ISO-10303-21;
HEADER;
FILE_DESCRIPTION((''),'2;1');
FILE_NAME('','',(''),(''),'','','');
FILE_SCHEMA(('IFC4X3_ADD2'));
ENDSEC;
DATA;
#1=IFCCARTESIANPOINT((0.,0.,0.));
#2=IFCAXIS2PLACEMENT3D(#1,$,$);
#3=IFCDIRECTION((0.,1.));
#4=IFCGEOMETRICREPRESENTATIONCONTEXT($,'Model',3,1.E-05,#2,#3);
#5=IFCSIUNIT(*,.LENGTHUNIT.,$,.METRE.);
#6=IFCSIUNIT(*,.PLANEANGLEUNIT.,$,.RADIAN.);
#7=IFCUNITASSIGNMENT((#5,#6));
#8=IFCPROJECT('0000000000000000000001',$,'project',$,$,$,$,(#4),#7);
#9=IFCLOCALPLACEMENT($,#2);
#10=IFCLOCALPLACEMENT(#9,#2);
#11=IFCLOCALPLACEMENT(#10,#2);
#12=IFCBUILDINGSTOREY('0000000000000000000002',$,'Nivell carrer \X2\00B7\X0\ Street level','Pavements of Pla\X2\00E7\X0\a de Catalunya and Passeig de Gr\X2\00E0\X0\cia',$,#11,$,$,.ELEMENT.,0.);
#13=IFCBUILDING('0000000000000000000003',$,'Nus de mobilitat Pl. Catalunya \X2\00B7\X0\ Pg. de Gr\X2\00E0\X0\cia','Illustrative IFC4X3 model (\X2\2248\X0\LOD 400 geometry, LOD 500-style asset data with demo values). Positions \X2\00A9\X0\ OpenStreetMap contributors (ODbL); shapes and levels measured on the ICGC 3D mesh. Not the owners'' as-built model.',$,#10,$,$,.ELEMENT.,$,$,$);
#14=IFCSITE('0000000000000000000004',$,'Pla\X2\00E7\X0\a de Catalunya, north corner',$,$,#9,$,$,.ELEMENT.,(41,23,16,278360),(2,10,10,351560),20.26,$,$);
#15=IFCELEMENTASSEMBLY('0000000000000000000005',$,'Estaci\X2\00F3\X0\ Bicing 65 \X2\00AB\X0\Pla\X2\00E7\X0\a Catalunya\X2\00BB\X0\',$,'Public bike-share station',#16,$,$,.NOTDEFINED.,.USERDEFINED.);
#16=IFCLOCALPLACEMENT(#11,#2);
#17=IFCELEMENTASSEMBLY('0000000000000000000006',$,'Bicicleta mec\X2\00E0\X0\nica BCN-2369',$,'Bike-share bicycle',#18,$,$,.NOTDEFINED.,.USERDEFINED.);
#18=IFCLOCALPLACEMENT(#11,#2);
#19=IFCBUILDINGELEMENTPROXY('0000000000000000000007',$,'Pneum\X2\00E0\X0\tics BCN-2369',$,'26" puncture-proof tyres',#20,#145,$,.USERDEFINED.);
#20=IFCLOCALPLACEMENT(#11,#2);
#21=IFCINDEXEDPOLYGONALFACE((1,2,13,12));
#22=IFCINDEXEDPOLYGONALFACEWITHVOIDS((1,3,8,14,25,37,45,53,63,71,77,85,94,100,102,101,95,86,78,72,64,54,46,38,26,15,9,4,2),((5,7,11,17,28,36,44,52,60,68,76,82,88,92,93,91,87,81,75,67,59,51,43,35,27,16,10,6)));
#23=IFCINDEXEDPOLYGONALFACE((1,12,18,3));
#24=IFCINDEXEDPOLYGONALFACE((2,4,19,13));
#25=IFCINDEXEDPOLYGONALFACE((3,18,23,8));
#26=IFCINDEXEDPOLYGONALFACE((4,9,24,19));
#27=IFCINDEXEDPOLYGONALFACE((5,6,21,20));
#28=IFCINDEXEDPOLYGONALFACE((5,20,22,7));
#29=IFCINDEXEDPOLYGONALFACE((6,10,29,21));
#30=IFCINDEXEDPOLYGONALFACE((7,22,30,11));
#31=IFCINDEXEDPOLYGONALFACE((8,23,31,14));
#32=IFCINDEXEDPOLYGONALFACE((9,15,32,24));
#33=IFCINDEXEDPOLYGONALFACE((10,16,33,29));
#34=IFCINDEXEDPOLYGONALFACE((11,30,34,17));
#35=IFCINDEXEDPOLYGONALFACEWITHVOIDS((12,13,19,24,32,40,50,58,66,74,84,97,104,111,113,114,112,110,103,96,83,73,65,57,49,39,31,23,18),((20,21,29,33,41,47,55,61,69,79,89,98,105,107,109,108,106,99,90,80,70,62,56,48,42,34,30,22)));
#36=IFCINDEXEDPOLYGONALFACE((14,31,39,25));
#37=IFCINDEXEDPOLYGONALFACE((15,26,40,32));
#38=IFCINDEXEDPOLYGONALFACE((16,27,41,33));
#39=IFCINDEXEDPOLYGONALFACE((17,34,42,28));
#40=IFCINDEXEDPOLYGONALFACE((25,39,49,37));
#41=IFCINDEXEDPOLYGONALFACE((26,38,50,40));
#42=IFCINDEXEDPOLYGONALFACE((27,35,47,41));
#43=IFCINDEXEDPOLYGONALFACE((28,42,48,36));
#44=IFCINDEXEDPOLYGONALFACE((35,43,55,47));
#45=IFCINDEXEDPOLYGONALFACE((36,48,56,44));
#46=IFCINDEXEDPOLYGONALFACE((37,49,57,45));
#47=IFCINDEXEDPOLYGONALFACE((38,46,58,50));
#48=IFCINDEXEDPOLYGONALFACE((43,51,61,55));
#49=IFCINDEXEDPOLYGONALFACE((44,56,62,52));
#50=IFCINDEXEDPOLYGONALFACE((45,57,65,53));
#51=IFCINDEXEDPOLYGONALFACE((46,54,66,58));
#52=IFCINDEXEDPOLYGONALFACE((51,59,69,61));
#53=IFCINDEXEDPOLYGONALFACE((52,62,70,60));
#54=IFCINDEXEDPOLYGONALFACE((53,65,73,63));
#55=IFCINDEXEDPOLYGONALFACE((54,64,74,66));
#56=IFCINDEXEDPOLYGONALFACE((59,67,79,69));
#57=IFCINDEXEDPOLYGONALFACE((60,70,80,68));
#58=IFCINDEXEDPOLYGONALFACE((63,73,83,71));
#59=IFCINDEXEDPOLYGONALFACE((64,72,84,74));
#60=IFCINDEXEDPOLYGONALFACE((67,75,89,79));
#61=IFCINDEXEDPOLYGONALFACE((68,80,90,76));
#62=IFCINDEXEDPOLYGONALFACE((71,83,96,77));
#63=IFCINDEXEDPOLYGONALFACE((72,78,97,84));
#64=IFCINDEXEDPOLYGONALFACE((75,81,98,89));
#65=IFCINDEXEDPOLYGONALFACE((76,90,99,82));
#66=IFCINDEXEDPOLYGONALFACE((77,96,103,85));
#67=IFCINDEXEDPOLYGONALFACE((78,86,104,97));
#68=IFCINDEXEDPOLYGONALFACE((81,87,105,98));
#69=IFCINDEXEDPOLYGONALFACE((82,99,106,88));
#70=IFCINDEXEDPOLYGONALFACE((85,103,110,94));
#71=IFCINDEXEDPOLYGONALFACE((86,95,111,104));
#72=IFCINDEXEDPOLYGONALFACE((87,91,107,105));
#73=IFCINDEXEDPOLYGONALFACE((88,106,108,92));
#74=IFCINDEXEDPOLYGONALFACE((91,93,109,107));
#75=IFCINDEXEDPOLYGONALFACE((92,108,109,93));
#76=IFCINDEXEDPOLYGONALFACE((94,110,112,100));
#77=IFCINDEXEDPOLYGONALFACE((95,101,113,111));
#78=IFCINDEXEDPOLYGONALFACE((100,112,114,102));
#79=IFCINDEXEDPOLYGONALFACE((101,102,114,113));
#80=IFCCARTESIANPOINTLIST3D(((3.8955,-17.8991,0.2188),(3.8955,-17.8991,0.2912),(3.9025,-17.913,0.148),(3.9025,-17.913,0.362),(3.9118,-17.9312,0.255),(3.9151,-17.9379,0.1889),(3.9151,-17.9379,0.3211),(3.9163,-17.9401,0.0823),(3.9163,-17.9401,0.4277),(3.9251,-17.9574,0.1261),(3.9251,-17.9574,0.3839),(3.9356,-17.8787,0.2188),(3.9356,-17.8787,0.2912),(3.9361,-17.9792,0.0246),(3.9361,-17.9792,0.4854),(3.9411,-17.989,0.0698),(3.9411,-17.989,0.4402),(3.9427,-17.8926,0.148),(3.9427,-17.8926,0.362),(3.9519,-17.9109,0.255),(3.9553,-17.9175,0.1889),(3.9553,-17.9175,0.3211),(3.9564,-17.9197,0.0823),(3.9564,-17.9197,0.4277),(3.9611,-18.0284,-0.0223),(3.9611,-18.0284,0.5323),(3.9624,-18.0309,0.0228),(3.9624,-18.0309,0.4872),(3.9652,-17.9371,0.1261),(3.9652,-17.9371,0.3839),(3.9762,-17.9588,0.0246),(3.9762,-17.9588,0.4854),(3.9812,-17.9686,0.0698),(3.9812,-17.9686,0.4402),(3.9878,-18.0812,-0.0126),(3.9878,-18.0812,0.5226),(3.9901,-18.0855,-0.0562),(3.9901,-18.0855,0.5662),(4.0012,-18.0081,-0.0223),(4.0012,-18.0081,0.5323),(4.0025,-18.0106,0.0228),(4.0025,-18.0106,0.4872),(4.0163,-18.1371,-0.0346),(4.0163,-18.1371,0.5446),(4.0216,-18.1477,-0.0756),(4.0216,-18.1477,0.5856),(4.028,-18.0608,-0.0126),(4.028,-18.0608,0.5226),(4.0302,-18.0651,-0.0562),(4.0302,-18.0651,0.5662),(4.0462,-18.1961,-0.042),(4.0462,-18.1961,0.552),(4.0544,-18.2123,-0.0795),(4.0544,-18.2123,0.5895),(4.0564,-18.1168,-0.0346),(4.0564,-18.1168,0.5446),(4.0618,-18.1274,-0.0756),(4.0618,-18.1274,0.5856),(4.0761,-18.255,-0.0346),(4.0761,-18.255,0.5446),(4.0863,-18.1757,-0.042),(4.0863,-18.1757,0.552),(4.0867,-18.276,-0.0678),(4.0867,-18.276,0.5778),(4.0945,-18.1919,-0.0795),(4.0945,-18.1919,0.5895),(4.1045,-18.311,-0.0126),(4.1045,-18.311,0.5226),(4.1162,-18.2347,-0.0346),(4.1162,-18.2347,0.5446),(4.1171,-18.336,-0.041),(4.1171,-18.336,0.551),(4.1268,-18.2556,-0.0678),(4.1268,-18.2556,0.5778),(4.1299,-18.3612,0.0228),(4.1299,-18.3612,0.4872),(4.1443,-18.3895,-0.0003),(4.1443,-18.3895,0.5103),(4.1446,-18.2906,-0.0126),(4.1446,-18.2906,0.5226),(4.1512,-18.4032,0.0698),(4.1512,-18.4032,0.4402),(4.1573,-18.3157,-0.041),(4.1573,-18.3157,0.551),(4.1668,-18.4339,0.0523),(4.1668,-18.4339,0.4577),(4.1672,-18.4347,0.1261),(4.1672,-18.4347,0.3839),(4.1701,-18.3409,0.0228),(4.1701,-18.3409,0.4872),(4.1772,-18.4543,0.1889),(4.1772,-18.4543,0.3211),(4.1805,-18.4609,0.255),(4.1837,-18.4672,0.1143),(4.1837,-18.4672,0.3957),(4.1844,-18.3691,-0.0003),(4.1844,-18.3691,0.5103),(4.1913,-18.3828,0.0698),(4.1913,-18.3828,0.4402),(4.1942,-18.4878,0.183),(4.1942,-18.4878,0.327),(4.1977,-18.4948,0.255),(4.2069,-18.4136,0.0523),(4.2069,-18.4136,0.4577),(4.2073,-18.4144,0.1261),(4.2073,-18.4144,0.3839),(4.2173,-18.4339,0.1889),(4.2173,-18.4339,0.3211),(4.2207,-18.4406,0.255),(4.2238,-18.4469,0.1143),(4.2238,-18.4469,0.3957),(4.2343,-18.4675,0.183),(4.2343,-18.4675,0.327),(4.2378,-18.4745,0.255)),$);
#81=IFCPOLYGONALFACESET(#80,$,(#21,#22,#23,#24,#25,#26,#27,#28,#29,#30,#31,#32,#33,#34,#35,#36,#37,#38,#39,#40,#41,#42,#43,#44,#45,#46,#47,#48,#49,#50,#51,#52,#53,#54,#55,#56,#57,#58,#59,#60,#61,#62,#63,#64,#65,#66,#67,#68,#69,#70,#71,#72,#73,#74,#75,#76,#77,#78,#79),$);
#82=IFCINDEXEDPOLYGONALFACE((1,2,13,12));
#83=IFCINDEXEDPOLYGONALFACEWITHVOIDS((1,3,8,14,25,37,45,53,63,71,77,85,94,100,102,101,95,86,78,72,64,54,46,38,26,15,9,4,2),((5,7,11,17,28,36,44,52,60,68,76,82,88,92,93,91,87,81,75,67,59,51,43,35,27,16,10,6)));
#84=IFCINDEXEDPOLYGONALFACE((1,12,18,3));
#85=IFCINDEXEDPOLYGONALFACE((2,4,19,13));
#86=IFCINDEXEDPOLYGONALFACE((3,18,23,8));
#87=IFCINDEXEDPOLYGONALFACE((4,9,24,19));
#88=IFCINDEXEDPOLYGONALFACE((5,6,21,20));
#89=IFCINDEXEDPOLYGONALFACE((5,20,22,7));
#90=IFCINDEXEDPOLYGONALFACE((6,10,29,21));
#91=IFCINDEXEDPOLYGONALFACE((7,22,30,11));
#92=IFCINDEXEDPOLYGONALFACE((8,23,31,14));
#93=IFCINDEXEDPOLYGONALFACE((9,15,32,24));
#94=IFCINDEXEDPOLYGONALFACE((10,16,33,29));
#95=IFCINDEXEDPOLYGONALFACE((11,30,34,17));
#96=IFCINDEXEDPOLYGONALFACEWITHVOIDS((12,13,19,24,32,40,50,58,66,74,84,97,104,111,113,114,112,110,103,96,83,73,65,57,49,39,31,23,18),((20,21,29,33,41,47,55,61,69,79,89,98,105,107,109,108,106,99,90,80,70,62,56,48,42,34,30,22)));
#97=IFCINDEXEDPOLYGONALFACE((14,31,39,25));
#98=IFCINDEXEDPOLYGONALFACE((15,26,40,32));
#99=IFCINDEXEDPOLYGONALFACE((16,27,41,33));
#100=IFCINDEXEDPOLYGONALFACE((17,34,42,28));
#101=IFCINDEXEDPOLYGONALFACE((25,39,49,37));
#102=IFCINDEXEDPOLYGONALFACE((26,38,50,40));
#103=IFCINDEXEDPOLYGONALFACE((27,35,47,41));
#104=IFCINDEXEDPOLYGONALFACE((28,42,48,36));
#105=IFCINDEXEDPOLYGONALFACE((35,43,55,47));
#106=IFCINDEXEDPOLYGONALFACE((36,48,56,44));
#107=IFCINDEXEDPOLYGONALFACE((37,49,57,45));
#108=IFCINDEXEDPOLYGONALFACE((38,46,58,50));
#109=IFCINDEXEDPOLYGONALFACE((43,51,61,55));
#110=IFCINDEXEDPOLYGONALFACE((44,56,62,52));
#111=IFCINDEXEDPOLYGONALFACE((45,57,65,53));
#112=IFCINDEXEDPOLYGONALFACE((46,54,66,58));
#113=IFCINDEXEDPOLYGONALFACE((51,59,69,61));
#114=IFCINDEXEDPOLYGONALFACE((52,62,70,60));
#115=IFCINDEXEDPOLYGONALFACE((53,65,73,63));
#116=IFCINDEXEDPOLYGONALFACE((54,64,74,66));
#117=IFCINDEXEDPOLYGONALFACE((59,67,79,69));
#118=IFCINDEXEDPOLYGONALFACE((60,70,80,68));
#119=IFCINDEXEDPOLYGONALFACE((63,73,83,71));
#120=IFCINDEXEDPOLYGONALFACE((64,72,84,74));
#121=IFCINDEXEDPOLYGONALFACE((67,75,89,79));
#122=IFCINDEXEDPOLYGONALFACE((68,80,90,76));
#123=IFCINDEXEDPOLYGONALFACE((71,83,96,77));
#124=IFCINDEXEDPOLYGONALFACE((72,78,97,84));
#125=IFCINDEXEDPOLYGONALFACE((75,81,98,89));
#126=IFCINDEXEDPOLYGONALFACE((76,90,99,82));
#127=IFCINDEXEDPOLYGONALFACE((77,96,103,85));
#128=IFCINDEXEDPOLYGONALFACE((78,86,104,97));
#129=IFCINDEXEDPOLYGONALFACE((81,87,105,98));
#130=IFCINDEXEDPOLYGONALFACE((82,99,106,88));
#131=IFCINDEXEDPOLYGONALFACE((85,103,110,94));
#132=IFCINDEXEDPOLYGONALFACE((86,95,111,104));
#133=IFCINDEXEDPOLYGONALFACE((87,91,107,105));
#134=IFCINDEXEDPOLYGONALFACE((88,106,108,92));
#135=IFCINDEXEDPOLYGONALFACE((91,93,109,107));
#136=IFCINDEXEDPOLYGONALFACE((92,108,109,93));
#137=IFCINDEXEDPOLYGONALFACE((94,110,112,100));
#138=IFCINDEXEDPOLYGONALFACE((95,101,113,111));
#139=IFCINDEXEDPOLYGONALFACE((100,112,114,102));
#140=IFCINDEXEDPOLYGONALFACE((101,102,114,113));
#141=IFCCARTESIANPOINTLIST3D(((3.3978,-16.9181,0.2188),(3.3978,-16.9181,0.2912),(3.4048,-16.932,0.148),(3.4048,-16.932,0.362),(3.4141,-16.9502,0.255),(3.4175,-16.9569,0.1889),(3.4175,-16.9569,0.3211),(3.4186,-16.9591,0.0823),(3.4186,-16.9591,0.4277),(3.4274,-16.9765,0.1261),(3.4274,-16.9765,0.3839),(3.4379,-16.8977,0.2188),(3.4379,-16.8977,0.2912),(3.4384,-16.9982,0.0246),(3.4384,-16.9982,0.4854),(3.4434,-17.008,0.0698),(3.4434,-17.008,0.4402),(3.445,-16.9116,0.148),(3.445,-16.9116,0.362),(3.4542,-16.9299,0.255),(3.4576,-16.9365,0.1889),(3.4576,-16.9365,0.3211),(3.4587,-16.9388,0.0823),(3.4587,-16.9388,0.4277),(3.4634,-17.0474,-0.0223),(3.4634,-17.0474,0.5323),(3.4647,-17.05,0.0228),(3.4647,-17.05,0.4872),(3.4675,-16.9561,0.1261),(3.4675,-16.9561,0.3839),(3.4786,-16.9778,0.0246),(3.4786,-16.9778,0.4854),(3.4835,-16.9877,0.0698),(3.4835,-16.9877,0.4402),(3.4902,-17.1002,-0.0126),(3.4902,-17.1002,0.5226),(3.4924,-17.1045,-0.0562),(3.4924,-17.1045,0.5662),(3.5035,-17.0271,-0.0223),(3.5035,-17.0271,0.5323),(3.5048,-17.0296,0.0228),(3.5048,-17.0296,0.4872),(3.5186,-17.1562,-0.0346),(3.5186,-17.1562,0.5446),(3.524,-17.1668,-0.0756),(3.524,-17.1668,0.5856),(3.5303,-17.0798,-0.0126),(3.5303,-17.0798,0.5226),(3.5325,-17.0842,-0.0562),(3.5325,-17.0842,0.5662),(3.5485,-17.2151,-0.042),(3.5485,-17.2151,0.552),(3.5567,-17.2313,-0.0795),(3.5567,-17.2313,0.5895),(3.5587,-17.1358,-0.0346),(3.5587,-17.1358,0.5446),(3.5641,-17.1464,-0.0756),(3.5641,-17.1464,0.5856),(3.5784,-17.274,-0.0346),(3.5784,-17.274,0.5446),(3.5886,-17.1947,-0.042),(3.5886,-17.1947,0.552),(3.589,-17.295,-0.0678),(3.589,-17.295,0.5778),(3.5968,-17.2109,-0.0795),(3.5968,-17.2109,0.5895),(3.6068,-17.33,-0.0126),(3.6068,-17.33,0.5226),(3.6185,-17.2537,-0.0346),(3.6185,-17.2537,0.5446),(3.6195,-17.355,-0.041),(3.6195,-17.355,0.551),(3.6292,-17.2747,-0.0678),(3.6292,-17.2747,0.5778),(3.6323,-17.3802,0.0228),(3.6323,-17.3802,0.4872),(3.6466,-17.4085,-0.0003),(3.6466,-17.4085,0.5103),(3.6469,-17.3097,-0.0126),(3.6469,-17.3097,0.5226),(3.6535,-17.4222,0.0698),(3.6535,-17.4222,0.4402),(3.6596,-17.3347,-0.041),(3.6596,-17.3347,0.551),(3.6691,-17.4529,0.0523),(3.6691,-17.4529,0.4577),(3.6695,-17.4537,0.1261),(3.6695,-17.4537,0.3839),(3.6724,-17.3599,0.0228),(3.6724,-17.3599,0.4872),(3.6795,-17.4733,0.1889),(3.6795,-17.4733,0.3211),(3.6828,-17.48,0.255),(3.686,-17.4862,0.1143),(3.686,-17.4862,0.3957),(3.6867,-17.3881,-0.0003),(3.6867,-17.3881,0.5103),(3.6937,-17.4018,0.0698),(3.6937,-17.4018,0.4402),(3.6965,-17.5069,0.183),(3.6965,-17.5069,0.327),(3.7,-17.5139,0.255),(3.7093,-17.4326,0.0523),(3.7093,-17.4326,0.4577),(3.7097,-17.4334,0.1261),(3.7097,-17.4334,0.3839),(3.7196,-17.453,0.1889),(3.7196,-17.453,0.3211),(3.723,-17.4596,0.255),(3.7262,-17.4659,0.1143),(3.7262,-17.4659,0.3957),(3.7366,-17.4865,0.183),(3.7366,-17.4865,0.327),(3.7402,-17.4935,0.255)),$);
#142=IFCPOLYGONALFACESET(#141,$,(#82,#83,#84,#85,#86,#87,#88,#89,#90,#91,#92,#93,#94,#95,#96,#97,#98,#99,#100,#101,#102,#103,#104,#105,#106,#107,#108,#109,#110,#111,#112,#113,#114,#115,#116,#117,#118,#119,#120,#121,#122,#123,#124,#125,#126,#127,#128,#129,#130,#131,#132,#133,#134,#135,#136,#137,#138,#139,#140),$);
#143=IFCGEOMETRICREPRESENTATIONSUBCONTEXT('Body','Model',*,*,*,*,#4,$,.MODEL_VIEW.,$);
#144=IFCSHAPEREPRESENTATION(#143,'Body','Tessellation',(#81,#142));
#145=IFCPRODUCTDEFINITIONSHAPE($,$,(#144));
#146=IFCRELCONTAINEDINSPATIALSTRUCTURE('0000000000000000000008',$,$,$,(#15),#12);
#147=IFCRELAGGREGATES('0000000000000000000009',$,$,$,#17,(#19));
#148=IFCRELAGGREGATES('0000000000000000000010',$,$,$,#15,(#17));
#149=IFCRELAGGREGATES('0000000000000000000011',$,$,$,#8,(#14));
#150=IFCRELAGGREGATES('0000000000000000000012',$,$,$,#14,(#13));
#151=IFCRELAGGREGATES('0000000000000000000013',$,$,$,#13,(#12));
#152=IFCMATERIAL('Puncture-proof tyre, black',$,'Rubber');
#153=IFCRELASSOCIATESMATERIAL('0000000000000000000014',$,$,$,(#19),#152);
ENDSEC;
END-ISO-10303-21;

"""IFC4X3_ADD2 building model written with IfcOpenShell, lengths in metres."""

from ifc_helpers import new_model, si_unit, direction, frame, origin, origin_2d_with_axis, place, context, subcontext, project, spatial, hollow_circle, extrude, material, element, aggregate, save


model = new_model("IFC4X3_ADD2")

# Units and contexts
model_context = context("Model", 3, precision=1e-05, world=origin(), true_north=direction((0.0, 1.0)))
body_context = subcontext(model_context, "Body", "Model", "MODEL_VIEW")
ifc_project = project(units=[si_unit("LENGTHUNIT", "METRE"), si_unit("PLANEANGLEUNIT", "RADIAN")], contexts=[model_context])

# Site, building, storey
site_placement = place(None, origin())
site = spatial("IfcSite", under=ifc_project, at=site_placement, Name="Plaça de Catalunya, north corner", CompositionType="ELEMENT", RefLatitude=(41, 23, 16, 278360), RefLongitude=(2, 10, 10, 351560), RefElevation=20.26)
building_placement = place(site_placement, origin())
building = spatial("IfcBuilding", under=site, at=building_placement, Name="Nus de mobilitat Pl. Catalunya · Pg. de Gràcia", Description="Illustrative IFC4X3 model (≈LOD 400 geometry, LOD 500-style asset data with demo values). Positions © OpenStreetMap contributors (ODbL); shapes and levels measured on the ICGC 3D mesh. Not the owners' as-built model.", CompositionType="ELEMENT")
storey_placement = place(building_placement, origin())
storey = spatial("IfcBuildingStorey", under=building, at=storey_placement, Name="Nivell carrer · Street level", Description="Pavements of Plaça de Catalunya and Passeig de Gràcia", CompositionType="ELEMENT", Elevation=0.0)

# Element assemblies, building element proxy
assembly_1_placement = place(building_placement, origin())
assembly_1 = element("IfcElementAssembly", 1, at=assembly_1_placement, inside=storey, Name="Estació Bicing 65 «Plaça Catalunya»", ObjectType="Public bike-share station", AssemblyPlace="NOTDEFINED", PredefinedType="USERDEFINED")
assembly_2_placement = place(building_placement, origin())
assembly_2 = element("IfcElementAssembly", 2, at=assembly_2_placement, Name="Bicicleta mecànica BCN-2369", ObjectType="Bike-share bicycle", AssemblyPlace="NOTDEFINED", PredefinedType="USERDEFINED")
ifc_material_1 = material(Name="Puncture-proof tyre, black", Category="Rubber")
proxy_1_placement = place(building_placement, origin())
proxy_1 = element("IfcBuildingElementProxy", 3, at=proxy_1_placement, material=ifc_material_1, Name="Pneumàtics BCN-2369", ObjectType="26\" puncture-proof tyres", PredefinedType="USERDEFINED", context=body_context, shape_type="SweptSolid", body=[
    extrude(hollow_circle(Radius=0.335, WallThickness=0.038, at=origin_2d_with_axis()), frame((4.0462, -18.1961, 0.255), z_axis=(0.891798, 0.452435, 0.0), x_axis=(0.452435, -0.891798, 0.0)), (0.0, 0.0, 1.0), 0.045),
    extrude(hollow_circle(Radius=0.335, WallThickness=0.038, at=origin_2d_with_axis()), frame((3.5485, -17.2151, 0.255), z_axis=(0.891798, 0.452435, 0.0), x_axis=(0.452435, -0.891798, 0.0)), (0.0, 0.0, 1.0), 0.045),
])
aggregate(assembly_2, [proxy_1])
aggregate(assembly_1, [assembly_2])

save(model, "model.ifc")
